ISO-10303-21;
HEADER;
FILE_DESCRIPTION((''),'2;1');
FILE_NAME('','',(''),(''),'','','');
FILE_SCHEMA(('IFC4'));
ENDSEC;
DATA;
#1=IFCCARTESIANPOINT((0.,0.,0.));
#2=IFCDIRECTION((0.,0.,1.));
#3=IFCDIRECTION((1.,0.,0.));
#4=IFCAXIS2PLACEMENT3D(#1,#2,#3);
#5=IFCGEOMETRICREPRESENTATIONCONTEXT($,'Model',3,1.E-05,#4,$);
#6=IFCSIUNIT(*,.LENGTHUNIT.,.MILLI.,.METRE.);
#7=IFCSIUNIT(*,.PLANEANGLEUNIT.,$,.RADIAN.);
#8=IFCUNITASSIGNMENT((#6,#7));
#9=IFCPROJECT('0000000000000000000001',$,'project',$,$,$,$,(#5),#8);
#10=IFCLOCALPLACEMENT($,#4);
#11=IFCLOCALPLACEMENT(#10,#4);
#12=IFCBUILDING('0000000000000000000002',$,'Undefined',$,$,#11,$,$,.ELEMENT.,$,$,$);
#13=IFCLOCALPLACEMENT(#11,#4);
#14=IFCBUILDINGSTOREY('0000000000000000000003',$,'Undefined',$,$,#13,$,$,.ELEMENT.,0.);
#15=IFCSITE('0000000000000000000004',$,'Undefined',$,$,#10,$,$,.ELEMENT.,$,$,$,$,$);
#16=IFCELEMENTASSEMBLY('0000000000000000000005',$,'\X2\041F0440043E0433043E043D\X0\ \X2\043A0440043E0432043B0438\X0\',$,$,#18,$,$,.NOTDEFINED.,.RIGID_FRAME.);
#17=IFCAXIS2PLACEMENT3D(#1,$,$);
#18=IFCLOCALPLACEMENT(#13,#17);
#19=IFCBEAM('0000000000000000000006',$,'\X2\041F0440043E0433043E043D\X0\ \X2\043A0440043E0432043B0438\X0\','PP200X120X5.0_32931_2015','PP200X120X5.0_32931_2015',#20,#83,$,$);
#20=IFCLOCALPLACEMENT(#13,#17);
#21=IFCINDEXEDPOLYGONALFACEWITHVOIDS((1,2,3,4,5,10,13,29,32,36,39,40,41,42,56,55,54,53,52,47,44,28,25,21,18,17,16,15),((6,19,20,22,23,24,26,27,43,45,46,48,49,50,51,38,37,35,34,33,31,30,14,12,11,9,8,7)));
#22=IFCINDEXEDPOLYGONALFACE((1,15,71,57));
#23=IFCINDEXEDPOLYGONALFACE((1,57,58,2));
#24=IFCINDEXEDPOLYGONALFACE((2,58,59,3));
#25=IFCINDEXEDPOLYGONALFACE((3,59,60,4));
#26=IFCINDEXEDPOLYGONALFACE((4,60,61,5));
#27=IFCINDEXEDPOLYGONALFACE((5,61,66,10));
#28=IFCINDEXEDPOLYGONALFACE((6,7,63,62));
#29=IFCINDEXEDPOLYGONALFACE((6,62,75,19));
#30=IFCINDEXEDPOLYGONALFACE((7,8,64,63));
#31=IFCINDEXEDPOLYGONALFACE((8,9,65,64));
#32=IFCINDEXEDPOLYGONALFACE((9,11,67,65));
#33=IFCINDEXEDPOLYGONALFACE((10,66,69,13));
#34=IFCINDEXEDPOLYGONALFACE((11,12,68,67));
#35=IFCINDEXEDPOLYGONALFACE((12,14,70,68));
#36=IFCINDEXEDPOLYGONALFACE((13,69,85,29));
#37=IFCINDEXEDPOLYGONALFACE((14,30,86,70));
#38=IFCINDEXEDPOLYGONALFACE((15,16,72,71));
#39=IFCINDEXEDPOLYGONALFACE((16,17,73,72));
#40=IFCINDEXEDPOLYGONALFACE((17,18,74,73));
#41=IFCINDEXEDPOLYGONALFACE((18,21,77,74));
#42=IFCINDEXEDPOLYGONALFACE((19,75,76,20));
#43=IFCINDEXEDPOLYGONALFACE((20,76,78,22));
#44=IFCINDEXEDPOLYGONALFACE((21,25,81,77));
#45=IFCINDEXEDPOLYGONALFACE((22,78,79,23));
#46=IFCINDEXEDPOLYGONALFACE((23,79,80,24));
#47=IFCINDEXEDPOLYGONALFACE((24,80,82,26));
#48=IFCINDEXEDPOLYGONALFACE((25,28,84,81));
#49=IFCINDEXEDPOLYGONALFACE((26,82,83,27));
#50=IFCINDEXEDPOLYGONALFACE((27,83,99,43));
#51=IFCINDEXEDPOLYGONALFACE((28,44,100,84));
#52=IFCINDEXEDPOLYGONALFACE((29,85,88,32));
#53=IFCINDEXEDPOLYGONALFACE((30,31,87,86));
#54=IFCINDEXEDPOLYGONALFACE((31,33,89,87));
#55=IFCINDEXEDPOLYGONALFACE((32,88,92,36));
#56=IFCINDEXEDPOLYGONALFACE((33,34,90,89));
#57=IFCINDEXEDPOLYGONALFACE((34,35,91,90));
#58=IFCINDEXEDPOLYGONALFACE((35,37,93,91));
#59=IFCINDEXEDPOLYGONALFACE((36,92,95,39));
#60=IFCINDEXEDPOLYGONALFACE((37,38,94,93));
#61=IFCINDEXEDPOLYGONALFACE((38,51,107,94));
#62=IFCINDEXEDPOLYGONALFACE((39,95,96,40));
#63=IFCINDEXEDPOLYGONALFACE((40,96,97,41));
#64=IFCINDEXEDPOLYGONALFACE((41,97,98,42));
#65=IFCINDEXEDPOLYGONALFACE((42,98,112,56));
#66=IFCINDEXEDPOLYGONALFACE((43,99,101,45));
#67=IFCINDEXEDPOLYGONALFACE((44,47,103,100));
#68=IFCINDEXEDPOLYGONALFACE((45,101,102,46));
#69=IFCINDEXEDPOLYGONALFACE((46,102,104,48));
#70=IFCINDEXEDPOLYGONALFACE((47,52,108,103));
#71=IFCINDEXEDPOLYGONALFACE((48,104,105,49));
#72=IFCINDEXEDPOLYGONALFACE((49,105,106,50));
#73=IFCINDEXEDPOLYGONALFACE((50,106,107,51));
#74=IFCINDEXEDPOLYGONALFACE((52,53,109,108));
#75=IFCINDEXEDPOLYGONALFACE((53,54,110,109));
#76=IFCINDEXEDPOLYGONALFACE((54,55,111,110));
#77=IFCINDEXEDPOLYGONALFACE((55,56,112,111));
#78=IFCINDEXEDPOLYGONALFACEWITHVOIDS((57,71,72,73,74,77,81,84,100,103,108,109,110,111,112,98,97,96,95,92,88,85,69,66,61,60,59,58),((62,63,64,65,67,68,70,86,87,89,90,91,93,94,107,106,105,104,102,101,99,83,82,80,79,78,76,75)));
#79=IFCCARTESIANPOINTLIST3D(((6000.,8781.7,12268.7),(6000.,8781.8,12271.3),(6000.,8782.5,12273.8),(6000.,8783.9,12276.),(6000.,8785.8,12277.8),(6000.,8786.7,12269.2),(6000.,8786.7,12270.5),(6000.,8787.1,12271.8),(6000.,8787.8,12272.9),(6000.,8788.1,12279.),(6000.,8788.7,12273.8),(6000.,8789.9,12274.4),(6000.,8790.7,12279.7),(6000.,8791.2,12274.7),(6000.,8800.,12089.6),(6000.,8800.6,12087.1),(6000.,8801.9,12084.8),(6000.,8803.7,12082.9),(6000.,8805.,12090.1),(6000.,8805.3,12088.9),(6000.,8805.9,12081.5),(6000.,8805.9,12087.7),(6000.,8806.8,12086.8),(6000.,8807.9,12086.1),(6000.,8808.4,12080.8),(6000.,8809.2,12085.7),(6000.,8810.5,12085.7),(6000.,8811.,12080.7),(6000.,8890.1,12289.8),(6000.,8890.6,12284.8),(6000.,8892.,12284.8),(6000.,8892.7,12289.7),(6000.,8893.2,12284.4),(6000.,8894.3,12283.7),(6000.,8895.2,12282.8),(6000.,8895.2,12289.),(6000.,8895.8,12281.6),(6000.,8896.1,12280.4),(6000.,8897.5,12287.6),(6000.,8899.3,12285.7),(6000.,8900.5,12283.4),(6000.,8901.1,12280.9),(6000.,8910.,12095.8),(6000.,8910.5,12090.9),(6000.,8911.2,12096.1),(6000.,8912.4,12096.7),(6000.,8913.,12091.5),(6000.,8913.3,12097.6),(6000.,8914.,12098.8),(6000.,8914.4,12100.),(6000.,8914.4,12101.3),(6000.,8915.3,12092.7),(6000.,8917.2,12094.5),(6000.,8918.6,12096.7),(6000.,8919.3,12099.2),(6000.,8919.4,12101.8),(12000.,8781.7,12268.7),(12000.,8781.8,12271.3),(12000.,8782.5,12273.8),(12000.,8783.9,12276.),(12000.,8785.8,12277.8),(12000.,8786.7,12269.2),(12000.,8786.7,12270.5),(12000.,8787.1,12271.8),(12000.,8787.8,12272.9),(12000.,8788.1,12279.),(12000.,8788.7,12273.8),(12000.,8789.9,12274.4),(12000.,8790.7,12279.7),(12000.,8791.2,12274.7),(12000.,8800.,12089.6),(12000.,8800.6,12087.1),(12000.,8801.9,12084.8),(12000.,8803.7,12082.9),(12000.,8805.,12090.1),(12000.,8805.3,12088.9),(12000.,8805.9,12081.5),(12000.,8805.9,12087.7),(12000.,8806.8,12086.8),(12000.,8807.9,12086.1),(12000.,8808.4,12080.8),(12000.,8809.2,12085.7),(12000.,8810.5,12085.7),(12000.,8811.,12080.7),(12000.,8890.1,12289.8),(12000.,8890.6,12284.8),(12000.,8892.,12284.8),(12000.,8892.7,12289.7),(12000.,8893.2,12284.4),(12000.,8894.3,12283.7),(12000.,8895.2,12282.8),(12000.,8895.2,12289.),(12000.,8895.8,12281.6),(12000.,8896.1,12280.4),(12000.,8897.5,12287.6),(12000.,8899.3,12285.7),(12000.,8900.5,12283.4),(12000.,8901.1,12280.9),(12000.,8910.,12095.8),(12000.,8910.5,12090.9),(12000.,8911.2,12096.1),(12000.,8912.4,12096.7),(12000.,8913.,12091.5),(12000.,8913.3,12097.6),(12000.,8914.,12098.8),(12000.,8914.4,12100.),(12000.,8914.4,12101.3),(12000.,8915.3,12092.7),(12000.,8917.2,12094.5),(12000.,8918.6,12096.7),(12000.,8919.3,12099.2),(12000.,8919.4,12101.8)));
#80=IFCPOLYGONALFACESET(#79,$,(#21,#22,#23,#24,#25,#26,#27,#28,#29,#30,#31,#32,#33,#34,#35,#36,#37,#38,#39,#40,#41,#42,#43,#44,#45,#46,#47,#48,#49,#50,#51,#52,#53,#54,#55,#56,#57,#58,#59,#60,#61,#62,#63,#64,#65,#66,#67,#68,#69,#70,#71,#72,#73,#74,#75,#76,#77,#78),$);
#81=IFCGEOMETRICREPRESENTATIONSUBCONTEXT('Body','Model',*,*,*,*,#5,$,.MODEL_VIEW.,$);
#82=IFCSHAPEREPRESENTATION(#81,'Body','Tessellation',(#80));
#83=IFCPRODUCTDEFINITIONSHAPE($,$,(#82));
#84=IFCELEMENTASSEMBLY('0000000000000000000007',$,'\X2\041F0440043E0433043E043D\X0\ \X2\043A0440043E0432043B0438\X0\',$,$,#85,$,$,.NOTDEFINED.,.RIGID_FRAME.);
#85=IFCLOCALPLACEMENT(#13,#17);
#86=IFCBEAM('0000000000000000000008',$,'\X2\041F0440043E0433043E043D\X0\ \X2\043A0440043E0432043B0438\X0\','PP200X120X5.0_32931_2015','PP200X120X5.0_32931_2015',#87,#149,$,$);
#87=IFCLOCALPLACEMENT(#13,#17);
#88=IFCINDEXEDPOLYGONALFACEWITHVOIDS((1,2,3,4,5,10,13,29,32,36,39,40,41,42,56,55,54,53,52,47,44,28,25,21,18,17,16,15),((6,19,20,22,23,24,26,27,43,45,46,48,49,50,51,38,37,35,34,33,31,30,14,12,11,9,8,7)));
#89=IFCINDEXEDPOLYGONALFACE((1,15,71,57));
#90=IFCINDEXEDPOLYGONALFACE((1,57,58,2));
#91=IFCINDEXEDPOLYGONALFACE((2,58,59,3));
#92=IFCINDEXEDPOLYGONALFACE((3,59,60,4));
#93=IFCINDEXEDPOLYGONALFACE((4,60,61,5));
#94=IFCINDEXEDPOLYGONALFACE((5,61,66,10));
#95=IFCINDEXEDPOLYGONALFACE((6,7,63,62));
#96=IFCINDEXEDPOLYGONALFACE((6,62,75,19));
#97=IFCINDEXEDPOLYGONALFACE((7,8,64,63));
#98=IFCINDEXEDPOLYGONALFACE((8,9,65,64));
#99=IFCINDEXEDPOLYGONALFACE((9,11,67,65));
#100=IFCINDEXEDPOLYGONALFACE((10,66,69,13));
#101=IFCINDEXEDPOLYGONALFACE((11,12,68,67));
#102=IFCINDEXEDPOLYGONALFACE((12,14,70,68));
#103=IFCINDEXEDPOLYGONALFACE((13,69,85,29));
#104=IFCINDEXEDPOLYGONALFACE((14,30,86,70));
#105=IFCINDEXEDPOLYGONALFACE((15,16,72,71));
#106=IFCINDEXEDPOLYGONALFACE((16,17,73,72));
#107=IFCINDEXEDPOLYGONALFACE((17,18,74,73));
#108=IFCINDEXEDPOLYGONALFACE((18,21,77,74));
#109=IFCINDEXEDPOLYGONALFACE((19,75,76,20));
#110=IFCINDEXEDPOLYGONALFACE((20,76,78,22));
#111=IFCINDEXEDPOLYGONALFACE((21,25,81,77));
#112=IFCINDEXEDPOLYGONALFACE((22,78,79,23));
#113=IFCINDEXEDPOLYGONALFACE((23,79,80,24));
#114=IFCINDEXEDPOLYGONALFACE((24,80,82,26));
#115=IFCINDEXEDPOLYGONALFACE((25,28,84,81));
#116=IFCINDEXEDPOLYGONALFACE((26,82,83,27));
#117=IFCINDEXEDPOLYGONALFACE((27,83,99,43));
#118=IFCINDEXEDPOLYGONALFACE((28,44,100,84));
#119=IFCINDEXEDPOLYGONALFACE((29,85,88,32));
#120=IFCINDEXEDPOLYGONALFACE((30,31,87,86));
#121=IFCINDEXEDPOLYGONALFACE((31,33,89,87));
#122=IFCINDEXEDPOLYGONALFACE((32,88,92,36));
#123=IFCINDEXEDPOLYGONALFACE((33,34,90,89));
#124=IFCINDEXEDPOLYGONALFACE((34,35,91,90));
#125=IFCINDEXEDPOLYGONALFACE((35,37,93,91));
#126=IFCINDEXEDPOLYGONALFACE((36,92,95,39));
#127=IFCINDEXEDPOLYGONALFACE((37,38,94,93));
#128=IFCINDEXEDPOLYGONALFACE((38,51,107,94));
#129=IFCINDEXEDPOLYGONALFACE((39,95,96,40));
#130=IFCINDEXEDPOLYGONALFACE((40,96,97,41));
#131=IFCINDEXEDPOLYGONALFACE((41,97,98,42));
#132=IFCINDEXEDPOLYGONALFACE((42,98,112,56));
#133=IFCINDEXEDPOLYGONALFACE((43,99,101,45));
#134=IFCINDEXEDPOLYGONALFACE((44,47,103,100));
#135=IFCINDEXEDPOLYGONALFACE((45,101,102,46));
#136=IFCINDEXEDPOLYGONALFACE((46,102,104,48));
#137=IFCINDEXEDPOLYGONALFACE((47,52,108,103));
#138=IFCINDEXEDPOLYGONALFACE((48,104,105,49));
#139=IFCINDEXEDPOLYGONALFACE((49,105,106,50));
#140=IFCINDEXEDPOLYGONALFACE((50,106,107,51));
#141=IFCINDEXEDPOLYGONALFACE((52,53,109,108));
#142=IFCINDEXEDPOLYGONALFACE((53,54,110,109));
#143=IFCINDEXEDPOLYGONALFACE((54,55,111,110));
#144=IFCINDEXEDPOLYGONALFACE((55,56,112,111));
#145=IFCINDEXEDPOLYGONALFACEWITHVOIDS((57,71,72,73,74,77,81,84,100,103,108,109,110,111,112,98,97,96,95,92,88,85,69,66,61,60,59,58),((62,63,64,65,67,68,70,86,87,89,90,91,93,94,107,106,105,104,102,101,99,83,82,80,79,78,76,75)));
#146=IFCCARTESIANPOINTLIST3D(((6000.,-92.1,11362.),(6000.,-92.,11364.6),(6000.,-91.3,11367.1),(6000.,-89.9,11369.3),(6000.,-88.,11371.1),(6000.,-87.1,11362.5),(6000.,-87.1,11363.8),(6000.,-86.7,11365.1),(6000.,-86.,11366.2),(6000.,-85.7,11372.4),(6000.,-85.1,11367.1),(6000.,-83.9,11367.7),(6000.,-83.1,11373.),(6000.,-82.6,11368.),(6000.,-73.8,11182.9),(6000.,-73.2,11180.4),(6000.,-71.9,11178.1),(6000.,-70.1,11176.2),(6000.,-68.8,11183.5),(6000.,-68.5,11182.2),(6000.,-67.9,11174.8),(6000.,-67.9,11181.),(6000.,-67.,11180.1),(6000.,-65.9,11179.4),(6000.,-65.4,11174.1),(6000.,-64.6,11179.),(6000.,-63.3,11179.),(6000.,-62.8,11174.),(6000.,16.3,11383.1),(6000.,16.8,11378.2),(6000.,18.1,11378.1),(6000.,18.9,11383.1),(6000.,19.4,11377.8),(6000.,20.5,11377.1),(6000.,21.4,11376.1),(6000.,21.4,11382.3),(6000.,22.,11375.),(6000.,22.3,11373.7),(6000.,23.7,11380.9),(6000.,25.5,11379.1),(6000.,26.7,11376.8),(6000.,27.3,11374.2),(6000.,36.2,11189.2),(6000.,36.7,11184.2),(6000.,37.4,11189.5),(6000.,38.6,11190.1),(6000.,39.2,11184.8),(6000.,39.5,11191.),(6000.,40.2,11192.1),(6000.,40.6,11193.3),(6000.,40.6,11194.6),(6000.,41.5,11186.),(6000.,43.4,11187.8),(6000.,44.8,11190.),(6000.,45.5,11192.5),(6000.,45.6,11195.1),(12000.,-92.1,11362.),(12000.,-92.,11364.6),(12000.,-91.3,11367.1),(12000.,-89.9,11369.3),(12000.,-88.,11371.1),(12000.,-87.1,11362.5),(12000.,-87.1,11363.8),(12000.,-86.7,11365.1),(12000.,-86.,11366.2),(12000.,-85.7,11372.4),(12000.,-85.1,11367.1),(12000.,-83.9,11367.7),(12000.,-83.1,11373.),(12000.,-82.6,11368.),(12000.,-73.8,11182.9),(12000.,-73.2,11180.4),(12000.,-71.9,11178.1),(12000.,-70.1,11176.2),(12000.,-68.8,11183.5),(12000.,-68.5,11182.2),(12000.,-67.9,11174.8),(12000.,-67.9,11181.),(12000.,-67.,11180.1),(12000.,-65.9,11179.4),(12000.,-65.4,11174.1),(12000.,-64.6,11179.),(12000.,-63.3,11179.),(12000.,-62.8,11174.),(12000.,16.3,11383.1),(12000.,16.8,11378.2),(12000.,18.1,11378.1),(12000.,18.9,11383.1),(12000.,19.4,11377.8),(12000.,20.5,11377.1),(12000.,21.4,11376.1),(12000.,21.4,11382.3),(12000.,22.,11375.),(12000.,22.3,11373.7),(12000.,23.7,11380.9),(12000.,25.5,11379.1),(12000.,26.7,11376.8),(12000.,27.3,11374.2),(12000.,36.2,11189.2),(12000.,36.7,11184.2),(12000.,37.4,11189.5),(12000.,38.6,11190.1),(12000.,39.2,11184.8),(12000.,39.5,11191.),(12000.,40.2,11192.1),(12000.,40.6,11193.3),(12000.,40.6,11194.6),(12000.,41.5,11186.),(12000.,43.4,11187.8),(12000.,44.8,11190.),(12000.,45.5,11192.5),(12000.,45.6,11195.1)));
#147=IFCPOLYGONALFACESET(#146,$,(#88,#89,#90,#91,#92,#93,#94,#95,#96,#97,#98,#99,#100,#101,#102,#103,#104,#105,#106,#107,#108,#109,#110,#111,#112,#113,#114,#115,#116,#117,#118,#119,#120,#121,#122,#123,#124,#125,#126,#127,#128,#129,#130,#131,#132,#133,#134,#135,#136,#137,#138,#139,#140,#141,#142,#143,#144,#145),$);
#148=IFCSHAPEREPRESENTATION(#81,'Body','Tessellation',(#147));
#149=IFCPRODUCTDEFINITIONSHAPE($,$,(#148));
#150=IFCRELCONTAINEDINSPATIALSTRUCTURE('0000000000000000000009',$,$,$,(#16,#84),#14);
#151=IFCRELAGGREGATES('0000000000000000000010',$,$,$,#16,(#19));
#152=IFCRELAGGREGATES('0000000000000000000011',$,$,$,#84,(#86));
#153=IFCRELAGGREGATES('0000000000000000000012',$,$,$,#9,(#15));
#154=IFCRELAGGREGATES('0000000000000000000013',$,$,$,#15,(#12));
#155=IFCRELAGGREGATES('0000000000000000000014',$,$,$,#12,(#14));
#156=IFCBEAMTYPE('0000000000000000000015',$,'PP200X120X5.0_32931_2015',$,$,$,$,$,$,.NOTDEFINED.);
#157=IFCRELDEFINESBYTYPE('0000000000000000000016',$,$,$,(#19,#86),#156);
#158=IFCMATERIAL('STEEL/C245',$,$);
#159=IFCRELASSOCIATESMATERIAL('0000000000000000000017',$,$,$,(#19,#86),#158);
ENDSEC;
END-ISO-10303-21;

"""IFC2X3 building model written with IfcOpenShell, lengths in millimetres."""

from ifc_helpers import new_model, si_unit, frame, origin_with_axes, origin_2d_with_axis, place, context, subcontext, project, spatial, hollow_rectangle, extrude, material, type_object, element, aggregate, save


model = new_model("IFC2X3")

# Units and contexts
model_context = context("Model", 3, precision=1e-05, world=origin_with_axes())
body_context = subcontext(model_context, "Body", "Model", "MODEL_VIEW")
ifc_project = project(units=[si_unit("LENGTHUNIT", "METRE", prefix="MILLI"), si_unit("PLANEANGLEUNIT", "RADIAN")], contexts=[model_context])

# Site, building, storey
site_placement = place(None, origin_with_axes())
site = spatial("IfcSite", under=ifc_project, at=site_placement, Name="Undefined", CompositionType="ELEMENT")
building_placement = place(site_placement, origin_with_axes())
building = spatial("IfcBuilding", under=site, at=building_placement, Name="Undefined", CompositionType="ELEMENT")
storey_placement = place(building_placement, origin_with_axes())
storey = spatial("IfcBuildingStorey", under=building, at=storey_placement, Name="Undefined", CompositionType="ELEMENT", Elevation=0.0)

# Element assemblies, beams
assembly_1_placement = place(storey_placement, origin_with_axes())
assembly_1 = element("IfcElementAssembly", 1, at=assembly_1_placement, inside=storey, Name="Прогон кровли", AssemblyPlace="NOTDEFINED", PredefinedType="RIGID_FRAME")
ifc_material_1 = material(Name="STEEL/C245")
beam_type_1 = type_object("IfcBeamType", Name="PP200X120X5.0_32931_2015", PredefinedType="NOTDEFINED")
beam_1_placement = place(assembly_1_placement, frame((12000.0, 8850.6, 12185.3), z_axis=(0.0, -0.101645, 0.994821), x_axis=(-1.0, 0.0, 0.0)))
beam_1 = element("IfcBeam", 2, at=beam_1_placement, type_object=beam_type_1, material=ifc_material_1, Name="Прогон кровли", Description="PP200X120X5.0_32931_2015", ObjectType="PP200X120X5.0_32931_2015", context=body_context, shape_type="SweptSolid", body=[
    extrude(hollow_rectangle(XDim=120.0, YDim=200.0, WallThickness=5.0, InnerFilletRadius=5.0, OuterFilletRadius=10.0, at=origin_2d_with_axis()), frame((6000.0, 0.0, 0.0), z_axis=(-1.0, 0.0, 0.0), x_axis=(0.0, -1.0, 0.0)), (0.0, 0.0, 1.0), 6000.0),
])
aggregate(assembly_1, [beam_1])
assembly_2_placement = place(storey_placement, origin_with_axes())
assembly_2 = element("IfcElementAssembly", 3, at=assembly_2_placement, inside=storey, Name="Прогон кровли", AssemblyPlace="NOTDEFINED", PredefinedType="RIGID_FRAME")
beam_2_placement = place(assembly_2_placement, frame((12000.0, -23.2, 11278.6), z_axis=(0.0, -0.101645, 0.994821), x_axis=(-1.0, 0.0, 0.0)))
beam_2 = element("IfcBeam", 4, at=beam_2_placement, type_object=beam_type_1, material=ifc_material_1, Name="Прогон кровли", Description="PP200X120X5.0_32931_2015", ObjectType="PP200X120X5.0_32931_2015", context=body_context, shape_type="SweptSolid", body=[
    extrude(hollow_rectangle(XDim=120.0, YDim=200.0, WallThickness=5.0, InnerFilletRadius=5.0, OuterFilletRadius=10.0, at=origin_2d_with_axis()), frame((6000.0, 0.0, 0.0), z_axis=(-1.0, 0.0, 0.0), x_axis=(0.0, -1.0, 0.0)), (0.0, 0.0, 1.0), 6000.0),
])
aggregate(assembly_2, [beam_2])

save(model, "model.ifc")
